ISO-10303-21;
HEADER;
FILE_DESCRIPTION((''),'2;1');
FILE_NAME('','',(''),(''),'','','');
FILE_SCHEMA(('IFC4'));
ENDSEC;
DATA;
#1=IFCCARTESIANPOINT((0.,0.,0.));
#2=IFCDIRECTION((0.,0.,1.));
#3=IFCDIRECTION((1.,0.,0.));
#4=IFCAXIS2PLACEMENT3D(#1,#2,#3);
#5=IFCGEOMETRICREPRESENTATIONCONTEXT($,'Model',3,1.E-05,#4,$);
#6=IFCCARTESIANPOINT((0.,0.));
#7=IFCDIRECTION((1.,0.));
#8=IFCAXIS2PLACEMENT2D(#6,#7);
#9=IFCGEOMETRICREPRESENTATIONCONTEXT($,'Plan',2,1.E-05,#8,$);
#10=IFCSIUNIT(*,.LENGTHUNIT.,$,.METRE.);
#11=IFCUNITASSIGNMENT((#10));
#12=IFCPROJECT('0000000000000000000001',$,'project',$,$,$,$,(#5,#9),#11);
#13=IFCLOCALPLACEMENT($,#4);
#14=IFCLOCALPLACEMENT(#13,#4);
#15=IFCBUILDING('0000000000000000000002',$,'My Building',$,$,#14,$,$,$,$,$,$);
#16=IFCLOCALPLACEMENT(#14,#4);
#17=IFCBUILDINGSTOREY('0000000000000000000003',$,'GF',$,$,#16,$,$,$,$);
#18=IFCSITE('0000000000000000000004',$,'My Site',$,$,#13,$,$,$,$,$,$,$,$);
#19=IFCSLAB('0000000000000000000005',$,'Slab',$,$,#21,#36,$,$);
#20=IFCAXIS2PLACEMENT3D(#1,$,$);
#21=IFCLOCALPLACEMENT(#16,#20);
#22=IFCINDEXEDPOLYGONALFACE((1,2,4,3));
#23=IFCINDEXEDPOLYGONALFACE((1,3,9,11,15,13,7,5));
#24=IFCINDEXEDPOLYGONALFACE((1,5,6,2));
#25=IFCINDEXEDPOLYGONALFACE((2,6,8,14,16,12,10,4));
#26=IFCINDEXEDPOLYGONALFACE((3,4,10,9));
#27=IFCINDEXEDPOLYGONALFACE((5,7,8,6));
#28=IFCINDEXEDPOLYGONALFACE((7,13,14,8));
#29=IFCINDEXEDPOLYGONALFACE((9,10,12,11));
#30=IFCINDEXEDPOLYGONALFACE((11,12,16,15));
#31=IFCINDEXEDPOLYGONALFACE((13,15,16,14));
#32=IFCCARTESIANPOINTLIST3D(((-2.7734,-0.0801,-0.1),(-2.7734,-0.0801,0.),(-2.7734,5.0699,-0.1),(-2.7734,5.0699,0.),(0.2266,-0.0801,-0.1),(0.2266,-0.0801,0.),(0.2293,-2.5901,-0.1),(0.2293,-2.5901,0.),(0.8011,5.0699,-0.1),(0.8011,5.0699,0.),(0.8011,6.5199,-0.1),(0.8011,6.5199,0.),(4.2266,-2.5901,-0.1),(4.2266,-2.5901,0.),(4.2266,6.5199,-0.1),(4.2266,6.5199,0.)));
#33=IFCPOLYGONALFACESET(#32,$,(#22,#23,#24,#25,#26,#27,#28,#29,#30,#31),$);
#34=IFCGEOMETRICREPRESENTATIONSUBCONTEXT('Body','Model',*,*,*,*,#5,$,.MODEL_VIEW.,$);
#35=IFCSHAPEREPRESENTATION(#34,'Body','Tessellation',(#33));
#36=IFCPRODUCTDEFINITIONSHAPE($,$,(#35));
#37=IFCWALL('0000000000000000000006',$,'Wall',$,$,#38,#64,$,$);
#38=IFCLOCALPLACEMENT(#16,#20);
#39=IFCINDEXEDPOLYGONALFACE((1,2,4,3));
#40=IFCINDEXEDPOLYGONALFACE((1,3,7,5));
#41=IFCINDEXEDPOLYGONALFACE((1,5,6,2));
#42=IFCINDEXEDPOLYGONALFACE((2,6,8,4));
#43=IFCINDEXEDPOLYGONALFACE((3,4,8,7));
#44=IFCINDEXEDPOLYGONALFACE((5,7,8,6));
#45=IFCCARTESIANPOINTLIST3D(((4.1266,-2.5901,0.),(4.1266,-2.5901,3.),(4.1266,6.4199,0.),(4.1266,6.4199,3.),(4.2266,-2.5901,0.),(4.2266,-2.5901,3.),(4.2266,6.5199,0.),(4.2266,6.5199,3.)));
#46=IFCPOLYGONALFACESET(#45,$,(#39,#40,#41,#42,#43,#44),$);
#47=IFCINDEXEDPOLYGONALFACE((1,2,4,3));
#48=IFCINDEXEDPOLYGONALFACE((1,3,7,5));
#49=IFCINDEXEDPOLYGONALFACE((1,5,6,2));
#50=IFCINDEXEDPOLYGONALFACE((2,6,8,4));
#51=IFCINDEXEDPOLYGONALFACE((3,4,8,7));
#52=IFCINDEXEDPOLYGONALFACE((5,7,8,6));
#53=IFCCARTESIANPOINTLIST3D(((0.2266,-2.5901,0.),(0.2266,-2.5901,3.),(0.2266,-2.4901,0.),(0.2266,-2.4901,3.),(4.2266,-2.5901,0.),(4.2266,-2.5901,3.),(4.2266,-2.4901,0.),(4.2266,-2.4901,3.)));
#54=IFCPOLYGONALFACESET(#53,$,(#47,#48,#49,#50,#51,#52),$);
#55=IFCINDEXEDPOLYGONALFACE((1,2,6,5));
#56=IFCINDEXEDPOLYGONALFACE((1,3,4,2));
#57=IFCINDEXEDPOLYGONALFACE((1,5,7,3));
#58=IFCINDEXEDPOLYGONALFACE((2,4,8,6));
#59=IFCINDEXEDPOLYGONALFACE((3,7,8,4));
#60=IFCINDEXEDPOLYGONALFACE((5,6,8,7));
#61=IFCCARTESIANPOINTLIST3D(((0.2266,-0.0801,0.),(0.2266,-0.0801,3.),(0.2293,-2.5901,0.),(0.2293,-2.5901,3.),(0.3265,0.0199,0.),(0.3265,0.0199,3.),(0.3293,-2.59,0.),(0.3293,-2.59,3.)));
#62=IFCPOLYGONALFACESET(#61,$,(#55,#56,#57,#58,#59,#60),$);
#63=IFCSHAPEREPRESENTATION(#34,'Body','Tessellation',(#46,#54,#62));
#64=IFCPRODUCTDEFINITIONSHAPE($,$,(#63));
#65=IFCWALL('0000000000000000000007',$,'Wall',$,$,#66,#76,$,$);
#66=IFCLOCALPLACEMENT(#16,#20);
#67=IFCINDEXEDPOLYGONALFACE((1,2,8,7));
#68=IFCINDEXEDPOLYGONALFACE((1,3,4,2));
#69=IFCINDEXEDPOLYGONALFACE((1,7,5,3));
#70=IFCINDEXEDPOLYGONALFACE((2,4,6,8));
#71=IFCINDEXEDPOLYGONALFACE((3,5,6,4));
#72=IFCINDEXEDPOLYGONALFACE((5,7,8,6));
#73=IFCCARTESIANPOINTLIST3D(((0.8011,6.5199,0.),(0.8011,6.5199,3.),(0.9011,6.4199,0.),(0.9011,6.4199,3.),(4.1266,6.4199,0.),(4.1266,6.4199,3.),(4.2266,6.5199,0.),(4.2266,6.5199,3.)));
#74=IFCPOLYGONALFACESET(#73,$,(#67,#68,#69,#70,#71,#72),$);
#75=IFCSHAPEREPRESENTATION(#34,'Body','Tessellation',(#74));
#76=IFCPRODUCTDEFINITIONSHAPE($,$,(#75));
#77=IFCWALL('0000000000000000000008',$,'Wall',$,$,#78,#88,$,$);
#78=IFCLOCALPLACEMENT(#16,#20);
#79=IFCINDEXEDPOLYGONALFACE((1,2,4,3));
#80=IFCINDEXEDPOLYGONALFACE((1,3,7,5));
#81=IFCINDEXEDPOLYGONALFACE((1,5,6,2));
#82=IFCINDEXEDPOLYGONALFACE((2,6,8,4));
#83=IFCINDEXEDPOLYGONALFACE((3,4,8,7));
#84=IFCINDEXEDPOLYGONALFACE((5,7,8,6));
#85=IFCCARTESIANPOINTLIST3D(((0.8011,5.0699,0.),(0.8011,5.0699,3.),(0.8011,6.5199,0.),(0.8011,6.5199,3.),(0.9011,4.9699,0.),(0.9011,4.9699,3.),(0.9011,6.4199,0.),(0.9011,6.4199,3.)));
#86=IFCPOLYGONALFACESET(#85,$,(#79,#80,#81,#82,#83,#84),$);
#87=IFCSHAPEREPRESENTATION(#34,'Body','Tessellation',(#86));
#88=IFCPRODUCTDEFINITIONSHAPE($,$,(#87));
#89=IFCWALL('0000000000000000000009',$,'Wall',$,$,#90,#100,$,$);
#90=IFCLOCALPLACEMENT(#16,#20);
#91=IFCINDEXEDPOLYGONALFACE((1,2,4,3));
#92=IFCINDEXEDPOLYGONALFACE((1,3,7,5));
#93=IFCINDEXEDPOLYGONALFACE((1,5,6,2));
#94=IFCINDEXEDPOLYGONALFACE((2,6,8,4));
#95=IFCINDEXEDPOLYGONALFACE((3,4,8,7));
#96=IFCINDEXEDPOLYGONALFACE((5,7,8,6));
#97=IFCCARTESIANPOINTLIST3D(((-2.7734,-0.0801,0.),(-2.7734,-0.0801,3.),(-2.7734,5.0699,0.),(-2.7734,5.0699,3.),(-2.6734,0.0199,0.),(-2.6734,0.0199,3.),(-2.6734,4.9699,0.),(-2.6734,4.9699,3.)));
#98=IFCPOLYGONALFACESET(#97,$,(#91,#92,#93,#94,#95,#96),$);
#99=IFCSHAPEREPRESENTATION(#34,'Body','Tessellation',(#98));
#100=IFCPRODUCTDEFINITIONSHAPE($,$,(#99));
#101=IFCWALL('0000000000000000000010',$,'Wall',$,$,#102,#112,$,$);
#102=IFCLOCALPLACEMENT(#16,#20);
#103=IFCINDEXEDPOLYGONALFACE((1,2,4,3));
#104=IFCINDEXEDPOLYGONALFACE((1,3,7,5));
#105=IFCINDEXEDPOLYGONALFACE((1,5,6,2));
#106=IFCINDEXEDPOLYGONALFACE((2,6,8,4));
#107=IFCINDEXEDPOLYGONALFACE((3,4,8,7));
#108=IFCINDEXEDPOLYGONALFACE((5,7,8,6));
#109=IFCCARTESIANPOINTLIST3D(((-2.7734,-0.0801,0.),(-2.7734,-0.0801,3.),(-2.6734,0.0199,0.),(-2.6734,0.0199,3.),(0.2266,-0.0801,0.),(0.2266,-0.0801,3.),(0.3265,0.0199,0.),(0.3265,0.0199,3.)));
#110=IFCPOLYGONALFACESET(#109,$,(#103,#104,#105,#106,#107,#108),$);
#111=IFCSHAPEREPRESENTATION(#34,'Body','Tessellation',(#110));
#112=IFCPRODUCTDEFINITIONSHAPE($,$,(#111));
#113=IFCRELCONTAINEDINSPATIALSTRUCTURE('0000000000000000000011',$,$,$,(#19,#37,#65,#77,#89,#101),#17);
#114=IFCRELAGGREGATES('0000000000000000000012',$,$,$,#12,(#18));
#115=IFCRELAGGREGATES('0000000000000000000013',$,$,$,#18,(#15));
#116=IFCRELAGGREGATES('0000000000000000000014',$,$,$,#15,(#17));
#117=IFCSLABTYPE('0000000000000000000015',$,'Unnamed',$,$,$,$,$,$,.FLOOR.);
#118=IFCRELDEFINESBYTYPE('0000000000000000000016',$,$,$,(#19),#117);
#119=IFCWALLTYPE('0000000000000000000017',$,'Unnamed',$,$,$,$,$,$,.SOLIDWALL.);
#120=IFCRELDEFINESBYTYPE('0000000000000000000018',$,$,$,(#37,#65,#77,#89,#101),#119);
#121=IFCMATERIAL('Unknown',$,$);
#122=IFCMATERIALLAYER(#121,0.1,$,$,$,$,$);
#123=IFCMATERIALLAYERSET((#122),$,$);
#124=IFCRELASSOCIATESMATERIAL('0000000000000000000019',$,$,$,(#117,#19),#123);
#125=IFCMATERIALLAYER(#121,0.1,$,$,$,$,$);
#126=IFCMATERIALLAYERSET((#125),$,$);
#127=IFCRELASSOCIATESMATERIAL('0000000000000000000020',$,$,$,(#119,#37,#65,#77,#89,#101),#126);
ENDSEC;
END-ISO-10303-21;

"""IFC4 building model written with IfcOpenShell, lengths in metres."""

from ifc_helpers import new_model, si_unit, frame, origin_with_axes, origin_2d_with_axis, place, context, subcontext, project, spatial, line, indexed_curve, outline, extrude, material, layer, layer_set, layer_usage, type_object, element, save


model = new_model("IFC4")

# Units and contexts
model_context = context("Model", 3, precision=1e-05, world=origin_with_axes())
plan_context = context("Plan", 2, precision=1e-05, world=origin_2d_with_axis())
body_context_1 = subcontext(model_context, "Body", "Model", "MODEL_VIEW")
ifc_project = project(units=[si_unit("LENGTHUNIT", "METRE")], contexts=[model_context, plan_context])

# Site, building, storey
site_placement = place(None, origin_with_axes())
site = spatial("IfcSite", under=ifc_project, at=site_placement, Name="My Site")
building_placement = place(site_placement, origin_with_axes())
building = spatial("IfcBuilding", under=site, at=building_placement, Name="My Building")
storey_placement = place(building_placement, origin_with_axes())
storey = spatial("IfcBuildingStorey", under=building, at=storey_placement, Name="GF")

# Slab
ifc_material = material(Name="Unknown")
ifc_layer_1 = layer(ifc_material, 0.1)
ifc_layer_set_1 = layer_set([ifc_layer_1])
ifc_layer_usage_1 = layer_usage(ifc_layer_set_1, "AXIS3", "POSITIVE", -0.1)
slab_type = type_object("IfcSlabType", Name="Unnamed", PredefinedType="FLOOR", material=ifc_layer_set_1)
slab_placement = place(storey_placement, frame((4.2266, -2.5901, 0.0), z_axis=(0.0, 0.0, 1.0), x_axis=(1.0, 0.0, 0.0)))
element("IfcSlab", 1, at=slab_placement, inside=storey, type_object=slab_type, material=ifc_layer_usage_1, Name="Slab", context=body_context_1, shape_type="SweptSolid", body=[
    extrude(outline(indexed_curve([(0.0, 0.0), (0.0, 9.11), (-3.4255, 9.11), (-3.4255, 7.66), (-7.0, 7.66), (-7.0, 2.51), (-4.0, 2.51), (-3.9973, 0.0), (0.0, 0.0)])), frame((0.0, 0.0, -0.1), z_axis=(0.0, 0.0, 1.0), x_axis=(1.0, 0.0, 0.0)), (0.0, 0.0, 1.0), 0.1),
])

# Walls
ifc_layer_2 = layer(ifc_material, 0.1)
ifc_layer_set_2 = layer_set([ifc_layer_2])
ifc_layer_usage_2 = layer_usage(ifc_layer_set_2, "AXIS2", "POSITIVE", 0.0)
wall_type = type_object("IfcWallType", Name="Unnamed", PredefinedType="SOLIDWALL", material=ifc_layer_set_2)
wall_1_placement = place(storey_placement, frame((4.2266, -2.5901, 0.0), z_axis=(0.0, 0.0, 1.0), x_axis=(0.0, 1.0, 0.0)))
element("IfcWall", 2, at=wall_1_placement, inside=storey, type_object=wall_type, material=ifc_layer_usage_2, Name="Wall", context=body_context_1, shape_type="SweptSolid", body=[
    extrude(outline(indexed_curve([(0.0, 0.0), (0.0, 0.1), (9.01, 0.1), (9.11, 0.0)], segments=[line(1, 2, 3, 4, 1)])), origin_with_axes(), (0.0, 0.0, 1.0), 3.0),
    extrude(outline(indexed_curve([(0.0, 0.0), (0.0, 0.1), (4.0, 0.1), (4.0, 0.0)], segments=[line(1, 2, 3, 4, 1)])), frame((0.0, 4.0, 0.0), z_axis=(0.0, 0.0, 1.0), x_axis=(0.0, -1.0, 0.0)), (0.0, 0.0, 1.0), 3.0),
    extrude(outline(indexed_curve([(0.0, 0.0), (-0.0999, 0.1), (2.51, 0.1), (2.51, 0.0)], segments=[line(1, 2, 3, 4, 1)])), frame((2.51, 4.0, 0.0), z_axis=(0.0, 0.0, 1.0), x_axis=(-0.999999, -0.001075, 0.0)), (0.0, 0.0, 1.0), 3.0),
])
ifc_layer_usage_3 = layer_usage(ifc_layer_set_2, "AXIS2", "POSITIVE", 0.0)
wall_2_placement = place(storey_placement, frame((4.2266, 6.5199, 0.0), z_axis=(0.0, 0.0, 1.0), x_axis=(-1.0, 0.0, 0.0)))
element("IfcWall", 3, at=wall_2_placement, inside=storey, type_object=wall_type, material=ifc_layer_usage_3, Name="Wall", context=body_context_1, shape_type="SweptSolid", body=[
    extrude(outline(indexed_curve([(0.0, 0.0), (0.1, 0.1), (3.3255, 0.1), (3.4255, 0.0)], segments=[line(1, 2, 3, 4, 1)])), origin_with_axes(), (0.0, 0.0, 1.0), 3.0),
])
ifc_layer_usage_4 = layer_usage(ifc_layer_set_2, "AXIS2", "POSITIVE", 0.0)
wall_3_placement = place(storey_placement, frame((0.8011, 6.5199, 0.0), z_axis=(0.0, 0.0, 1.0), x_axis=(0.0, -1.0, 0.0)))
element("IfcWall", 4, at=wall_3_placement, inside=storey, type_object=wall_type, material=ifc_layer_usage_4, Name="Wall", context=body_context_1, shape_type="SweptSolid", body=[
    extrude(outline(indexed_curve([(0.0, 0.0), (0.1, 0.1), (1.55, 0.1), (1.45, 0.0)], segments=[line(1, 2, 3, 4, 1)])), origin_with_axes(), (0.0, 0.0, 1.0), 3.0),
])
ifc_layer_usage_5 = layer_usage(ifc_layer_set_2, "AXIS2", "POSITIVE", 0.0)
wall_4_placement = place(storey_placement, frame((-2.7734, 5.0699, 0.0), z_axis=(0.0, 0.0, 1.0), x_axis=(0.0, -1.0, 0.0)))
element("IfcWall", 5, at=wall_4_placement, inside=storey, type_object=wall_type, material=ifc_layer_usage_5, Name="Wall", context=body_context_1, shape_type="SweptSolid", body=[
    extrude(outline(indexed_curve([(0.0, 0.0), (0.1, 0.1), (5.05, 0.1), (5.15, 0.0)], segments=[line(1, 2, 3, 4, 1)])), origin_with_axes(), (0.0, 0.0, 1.0), 3.0),
])
ifc_layer_usage_6 = layer_usage(ifc_layer_set_2, "AXIS2", "POSITIVE", 0.0)
wall_5_placement = place(storey_placement, frame((-2.7734, -0.0801, 0.0), z_axis=(0.0, 0.0, 1.0), x_axis=(1.0, 0.0, 0.0)))
element("IfcWall", 6, at=wall_5_placement, inside=storey, type_object=wall_type, material=ifc_layer_usage_6, Name="Wall", context=body_context_1, shape_type="SweptSolid", body=[
    extrude(outline(indexed_curve([(0.0, 0.0), (0.1, 0.1), (3.0999, 0.1), (3.0, 0.0)], segments=[line(1, 2, 3, 4, 1)])), origin_with_axes(), (0.0, 0.0, 1.0), 3.0),
])

save(model, "model.ifc")
